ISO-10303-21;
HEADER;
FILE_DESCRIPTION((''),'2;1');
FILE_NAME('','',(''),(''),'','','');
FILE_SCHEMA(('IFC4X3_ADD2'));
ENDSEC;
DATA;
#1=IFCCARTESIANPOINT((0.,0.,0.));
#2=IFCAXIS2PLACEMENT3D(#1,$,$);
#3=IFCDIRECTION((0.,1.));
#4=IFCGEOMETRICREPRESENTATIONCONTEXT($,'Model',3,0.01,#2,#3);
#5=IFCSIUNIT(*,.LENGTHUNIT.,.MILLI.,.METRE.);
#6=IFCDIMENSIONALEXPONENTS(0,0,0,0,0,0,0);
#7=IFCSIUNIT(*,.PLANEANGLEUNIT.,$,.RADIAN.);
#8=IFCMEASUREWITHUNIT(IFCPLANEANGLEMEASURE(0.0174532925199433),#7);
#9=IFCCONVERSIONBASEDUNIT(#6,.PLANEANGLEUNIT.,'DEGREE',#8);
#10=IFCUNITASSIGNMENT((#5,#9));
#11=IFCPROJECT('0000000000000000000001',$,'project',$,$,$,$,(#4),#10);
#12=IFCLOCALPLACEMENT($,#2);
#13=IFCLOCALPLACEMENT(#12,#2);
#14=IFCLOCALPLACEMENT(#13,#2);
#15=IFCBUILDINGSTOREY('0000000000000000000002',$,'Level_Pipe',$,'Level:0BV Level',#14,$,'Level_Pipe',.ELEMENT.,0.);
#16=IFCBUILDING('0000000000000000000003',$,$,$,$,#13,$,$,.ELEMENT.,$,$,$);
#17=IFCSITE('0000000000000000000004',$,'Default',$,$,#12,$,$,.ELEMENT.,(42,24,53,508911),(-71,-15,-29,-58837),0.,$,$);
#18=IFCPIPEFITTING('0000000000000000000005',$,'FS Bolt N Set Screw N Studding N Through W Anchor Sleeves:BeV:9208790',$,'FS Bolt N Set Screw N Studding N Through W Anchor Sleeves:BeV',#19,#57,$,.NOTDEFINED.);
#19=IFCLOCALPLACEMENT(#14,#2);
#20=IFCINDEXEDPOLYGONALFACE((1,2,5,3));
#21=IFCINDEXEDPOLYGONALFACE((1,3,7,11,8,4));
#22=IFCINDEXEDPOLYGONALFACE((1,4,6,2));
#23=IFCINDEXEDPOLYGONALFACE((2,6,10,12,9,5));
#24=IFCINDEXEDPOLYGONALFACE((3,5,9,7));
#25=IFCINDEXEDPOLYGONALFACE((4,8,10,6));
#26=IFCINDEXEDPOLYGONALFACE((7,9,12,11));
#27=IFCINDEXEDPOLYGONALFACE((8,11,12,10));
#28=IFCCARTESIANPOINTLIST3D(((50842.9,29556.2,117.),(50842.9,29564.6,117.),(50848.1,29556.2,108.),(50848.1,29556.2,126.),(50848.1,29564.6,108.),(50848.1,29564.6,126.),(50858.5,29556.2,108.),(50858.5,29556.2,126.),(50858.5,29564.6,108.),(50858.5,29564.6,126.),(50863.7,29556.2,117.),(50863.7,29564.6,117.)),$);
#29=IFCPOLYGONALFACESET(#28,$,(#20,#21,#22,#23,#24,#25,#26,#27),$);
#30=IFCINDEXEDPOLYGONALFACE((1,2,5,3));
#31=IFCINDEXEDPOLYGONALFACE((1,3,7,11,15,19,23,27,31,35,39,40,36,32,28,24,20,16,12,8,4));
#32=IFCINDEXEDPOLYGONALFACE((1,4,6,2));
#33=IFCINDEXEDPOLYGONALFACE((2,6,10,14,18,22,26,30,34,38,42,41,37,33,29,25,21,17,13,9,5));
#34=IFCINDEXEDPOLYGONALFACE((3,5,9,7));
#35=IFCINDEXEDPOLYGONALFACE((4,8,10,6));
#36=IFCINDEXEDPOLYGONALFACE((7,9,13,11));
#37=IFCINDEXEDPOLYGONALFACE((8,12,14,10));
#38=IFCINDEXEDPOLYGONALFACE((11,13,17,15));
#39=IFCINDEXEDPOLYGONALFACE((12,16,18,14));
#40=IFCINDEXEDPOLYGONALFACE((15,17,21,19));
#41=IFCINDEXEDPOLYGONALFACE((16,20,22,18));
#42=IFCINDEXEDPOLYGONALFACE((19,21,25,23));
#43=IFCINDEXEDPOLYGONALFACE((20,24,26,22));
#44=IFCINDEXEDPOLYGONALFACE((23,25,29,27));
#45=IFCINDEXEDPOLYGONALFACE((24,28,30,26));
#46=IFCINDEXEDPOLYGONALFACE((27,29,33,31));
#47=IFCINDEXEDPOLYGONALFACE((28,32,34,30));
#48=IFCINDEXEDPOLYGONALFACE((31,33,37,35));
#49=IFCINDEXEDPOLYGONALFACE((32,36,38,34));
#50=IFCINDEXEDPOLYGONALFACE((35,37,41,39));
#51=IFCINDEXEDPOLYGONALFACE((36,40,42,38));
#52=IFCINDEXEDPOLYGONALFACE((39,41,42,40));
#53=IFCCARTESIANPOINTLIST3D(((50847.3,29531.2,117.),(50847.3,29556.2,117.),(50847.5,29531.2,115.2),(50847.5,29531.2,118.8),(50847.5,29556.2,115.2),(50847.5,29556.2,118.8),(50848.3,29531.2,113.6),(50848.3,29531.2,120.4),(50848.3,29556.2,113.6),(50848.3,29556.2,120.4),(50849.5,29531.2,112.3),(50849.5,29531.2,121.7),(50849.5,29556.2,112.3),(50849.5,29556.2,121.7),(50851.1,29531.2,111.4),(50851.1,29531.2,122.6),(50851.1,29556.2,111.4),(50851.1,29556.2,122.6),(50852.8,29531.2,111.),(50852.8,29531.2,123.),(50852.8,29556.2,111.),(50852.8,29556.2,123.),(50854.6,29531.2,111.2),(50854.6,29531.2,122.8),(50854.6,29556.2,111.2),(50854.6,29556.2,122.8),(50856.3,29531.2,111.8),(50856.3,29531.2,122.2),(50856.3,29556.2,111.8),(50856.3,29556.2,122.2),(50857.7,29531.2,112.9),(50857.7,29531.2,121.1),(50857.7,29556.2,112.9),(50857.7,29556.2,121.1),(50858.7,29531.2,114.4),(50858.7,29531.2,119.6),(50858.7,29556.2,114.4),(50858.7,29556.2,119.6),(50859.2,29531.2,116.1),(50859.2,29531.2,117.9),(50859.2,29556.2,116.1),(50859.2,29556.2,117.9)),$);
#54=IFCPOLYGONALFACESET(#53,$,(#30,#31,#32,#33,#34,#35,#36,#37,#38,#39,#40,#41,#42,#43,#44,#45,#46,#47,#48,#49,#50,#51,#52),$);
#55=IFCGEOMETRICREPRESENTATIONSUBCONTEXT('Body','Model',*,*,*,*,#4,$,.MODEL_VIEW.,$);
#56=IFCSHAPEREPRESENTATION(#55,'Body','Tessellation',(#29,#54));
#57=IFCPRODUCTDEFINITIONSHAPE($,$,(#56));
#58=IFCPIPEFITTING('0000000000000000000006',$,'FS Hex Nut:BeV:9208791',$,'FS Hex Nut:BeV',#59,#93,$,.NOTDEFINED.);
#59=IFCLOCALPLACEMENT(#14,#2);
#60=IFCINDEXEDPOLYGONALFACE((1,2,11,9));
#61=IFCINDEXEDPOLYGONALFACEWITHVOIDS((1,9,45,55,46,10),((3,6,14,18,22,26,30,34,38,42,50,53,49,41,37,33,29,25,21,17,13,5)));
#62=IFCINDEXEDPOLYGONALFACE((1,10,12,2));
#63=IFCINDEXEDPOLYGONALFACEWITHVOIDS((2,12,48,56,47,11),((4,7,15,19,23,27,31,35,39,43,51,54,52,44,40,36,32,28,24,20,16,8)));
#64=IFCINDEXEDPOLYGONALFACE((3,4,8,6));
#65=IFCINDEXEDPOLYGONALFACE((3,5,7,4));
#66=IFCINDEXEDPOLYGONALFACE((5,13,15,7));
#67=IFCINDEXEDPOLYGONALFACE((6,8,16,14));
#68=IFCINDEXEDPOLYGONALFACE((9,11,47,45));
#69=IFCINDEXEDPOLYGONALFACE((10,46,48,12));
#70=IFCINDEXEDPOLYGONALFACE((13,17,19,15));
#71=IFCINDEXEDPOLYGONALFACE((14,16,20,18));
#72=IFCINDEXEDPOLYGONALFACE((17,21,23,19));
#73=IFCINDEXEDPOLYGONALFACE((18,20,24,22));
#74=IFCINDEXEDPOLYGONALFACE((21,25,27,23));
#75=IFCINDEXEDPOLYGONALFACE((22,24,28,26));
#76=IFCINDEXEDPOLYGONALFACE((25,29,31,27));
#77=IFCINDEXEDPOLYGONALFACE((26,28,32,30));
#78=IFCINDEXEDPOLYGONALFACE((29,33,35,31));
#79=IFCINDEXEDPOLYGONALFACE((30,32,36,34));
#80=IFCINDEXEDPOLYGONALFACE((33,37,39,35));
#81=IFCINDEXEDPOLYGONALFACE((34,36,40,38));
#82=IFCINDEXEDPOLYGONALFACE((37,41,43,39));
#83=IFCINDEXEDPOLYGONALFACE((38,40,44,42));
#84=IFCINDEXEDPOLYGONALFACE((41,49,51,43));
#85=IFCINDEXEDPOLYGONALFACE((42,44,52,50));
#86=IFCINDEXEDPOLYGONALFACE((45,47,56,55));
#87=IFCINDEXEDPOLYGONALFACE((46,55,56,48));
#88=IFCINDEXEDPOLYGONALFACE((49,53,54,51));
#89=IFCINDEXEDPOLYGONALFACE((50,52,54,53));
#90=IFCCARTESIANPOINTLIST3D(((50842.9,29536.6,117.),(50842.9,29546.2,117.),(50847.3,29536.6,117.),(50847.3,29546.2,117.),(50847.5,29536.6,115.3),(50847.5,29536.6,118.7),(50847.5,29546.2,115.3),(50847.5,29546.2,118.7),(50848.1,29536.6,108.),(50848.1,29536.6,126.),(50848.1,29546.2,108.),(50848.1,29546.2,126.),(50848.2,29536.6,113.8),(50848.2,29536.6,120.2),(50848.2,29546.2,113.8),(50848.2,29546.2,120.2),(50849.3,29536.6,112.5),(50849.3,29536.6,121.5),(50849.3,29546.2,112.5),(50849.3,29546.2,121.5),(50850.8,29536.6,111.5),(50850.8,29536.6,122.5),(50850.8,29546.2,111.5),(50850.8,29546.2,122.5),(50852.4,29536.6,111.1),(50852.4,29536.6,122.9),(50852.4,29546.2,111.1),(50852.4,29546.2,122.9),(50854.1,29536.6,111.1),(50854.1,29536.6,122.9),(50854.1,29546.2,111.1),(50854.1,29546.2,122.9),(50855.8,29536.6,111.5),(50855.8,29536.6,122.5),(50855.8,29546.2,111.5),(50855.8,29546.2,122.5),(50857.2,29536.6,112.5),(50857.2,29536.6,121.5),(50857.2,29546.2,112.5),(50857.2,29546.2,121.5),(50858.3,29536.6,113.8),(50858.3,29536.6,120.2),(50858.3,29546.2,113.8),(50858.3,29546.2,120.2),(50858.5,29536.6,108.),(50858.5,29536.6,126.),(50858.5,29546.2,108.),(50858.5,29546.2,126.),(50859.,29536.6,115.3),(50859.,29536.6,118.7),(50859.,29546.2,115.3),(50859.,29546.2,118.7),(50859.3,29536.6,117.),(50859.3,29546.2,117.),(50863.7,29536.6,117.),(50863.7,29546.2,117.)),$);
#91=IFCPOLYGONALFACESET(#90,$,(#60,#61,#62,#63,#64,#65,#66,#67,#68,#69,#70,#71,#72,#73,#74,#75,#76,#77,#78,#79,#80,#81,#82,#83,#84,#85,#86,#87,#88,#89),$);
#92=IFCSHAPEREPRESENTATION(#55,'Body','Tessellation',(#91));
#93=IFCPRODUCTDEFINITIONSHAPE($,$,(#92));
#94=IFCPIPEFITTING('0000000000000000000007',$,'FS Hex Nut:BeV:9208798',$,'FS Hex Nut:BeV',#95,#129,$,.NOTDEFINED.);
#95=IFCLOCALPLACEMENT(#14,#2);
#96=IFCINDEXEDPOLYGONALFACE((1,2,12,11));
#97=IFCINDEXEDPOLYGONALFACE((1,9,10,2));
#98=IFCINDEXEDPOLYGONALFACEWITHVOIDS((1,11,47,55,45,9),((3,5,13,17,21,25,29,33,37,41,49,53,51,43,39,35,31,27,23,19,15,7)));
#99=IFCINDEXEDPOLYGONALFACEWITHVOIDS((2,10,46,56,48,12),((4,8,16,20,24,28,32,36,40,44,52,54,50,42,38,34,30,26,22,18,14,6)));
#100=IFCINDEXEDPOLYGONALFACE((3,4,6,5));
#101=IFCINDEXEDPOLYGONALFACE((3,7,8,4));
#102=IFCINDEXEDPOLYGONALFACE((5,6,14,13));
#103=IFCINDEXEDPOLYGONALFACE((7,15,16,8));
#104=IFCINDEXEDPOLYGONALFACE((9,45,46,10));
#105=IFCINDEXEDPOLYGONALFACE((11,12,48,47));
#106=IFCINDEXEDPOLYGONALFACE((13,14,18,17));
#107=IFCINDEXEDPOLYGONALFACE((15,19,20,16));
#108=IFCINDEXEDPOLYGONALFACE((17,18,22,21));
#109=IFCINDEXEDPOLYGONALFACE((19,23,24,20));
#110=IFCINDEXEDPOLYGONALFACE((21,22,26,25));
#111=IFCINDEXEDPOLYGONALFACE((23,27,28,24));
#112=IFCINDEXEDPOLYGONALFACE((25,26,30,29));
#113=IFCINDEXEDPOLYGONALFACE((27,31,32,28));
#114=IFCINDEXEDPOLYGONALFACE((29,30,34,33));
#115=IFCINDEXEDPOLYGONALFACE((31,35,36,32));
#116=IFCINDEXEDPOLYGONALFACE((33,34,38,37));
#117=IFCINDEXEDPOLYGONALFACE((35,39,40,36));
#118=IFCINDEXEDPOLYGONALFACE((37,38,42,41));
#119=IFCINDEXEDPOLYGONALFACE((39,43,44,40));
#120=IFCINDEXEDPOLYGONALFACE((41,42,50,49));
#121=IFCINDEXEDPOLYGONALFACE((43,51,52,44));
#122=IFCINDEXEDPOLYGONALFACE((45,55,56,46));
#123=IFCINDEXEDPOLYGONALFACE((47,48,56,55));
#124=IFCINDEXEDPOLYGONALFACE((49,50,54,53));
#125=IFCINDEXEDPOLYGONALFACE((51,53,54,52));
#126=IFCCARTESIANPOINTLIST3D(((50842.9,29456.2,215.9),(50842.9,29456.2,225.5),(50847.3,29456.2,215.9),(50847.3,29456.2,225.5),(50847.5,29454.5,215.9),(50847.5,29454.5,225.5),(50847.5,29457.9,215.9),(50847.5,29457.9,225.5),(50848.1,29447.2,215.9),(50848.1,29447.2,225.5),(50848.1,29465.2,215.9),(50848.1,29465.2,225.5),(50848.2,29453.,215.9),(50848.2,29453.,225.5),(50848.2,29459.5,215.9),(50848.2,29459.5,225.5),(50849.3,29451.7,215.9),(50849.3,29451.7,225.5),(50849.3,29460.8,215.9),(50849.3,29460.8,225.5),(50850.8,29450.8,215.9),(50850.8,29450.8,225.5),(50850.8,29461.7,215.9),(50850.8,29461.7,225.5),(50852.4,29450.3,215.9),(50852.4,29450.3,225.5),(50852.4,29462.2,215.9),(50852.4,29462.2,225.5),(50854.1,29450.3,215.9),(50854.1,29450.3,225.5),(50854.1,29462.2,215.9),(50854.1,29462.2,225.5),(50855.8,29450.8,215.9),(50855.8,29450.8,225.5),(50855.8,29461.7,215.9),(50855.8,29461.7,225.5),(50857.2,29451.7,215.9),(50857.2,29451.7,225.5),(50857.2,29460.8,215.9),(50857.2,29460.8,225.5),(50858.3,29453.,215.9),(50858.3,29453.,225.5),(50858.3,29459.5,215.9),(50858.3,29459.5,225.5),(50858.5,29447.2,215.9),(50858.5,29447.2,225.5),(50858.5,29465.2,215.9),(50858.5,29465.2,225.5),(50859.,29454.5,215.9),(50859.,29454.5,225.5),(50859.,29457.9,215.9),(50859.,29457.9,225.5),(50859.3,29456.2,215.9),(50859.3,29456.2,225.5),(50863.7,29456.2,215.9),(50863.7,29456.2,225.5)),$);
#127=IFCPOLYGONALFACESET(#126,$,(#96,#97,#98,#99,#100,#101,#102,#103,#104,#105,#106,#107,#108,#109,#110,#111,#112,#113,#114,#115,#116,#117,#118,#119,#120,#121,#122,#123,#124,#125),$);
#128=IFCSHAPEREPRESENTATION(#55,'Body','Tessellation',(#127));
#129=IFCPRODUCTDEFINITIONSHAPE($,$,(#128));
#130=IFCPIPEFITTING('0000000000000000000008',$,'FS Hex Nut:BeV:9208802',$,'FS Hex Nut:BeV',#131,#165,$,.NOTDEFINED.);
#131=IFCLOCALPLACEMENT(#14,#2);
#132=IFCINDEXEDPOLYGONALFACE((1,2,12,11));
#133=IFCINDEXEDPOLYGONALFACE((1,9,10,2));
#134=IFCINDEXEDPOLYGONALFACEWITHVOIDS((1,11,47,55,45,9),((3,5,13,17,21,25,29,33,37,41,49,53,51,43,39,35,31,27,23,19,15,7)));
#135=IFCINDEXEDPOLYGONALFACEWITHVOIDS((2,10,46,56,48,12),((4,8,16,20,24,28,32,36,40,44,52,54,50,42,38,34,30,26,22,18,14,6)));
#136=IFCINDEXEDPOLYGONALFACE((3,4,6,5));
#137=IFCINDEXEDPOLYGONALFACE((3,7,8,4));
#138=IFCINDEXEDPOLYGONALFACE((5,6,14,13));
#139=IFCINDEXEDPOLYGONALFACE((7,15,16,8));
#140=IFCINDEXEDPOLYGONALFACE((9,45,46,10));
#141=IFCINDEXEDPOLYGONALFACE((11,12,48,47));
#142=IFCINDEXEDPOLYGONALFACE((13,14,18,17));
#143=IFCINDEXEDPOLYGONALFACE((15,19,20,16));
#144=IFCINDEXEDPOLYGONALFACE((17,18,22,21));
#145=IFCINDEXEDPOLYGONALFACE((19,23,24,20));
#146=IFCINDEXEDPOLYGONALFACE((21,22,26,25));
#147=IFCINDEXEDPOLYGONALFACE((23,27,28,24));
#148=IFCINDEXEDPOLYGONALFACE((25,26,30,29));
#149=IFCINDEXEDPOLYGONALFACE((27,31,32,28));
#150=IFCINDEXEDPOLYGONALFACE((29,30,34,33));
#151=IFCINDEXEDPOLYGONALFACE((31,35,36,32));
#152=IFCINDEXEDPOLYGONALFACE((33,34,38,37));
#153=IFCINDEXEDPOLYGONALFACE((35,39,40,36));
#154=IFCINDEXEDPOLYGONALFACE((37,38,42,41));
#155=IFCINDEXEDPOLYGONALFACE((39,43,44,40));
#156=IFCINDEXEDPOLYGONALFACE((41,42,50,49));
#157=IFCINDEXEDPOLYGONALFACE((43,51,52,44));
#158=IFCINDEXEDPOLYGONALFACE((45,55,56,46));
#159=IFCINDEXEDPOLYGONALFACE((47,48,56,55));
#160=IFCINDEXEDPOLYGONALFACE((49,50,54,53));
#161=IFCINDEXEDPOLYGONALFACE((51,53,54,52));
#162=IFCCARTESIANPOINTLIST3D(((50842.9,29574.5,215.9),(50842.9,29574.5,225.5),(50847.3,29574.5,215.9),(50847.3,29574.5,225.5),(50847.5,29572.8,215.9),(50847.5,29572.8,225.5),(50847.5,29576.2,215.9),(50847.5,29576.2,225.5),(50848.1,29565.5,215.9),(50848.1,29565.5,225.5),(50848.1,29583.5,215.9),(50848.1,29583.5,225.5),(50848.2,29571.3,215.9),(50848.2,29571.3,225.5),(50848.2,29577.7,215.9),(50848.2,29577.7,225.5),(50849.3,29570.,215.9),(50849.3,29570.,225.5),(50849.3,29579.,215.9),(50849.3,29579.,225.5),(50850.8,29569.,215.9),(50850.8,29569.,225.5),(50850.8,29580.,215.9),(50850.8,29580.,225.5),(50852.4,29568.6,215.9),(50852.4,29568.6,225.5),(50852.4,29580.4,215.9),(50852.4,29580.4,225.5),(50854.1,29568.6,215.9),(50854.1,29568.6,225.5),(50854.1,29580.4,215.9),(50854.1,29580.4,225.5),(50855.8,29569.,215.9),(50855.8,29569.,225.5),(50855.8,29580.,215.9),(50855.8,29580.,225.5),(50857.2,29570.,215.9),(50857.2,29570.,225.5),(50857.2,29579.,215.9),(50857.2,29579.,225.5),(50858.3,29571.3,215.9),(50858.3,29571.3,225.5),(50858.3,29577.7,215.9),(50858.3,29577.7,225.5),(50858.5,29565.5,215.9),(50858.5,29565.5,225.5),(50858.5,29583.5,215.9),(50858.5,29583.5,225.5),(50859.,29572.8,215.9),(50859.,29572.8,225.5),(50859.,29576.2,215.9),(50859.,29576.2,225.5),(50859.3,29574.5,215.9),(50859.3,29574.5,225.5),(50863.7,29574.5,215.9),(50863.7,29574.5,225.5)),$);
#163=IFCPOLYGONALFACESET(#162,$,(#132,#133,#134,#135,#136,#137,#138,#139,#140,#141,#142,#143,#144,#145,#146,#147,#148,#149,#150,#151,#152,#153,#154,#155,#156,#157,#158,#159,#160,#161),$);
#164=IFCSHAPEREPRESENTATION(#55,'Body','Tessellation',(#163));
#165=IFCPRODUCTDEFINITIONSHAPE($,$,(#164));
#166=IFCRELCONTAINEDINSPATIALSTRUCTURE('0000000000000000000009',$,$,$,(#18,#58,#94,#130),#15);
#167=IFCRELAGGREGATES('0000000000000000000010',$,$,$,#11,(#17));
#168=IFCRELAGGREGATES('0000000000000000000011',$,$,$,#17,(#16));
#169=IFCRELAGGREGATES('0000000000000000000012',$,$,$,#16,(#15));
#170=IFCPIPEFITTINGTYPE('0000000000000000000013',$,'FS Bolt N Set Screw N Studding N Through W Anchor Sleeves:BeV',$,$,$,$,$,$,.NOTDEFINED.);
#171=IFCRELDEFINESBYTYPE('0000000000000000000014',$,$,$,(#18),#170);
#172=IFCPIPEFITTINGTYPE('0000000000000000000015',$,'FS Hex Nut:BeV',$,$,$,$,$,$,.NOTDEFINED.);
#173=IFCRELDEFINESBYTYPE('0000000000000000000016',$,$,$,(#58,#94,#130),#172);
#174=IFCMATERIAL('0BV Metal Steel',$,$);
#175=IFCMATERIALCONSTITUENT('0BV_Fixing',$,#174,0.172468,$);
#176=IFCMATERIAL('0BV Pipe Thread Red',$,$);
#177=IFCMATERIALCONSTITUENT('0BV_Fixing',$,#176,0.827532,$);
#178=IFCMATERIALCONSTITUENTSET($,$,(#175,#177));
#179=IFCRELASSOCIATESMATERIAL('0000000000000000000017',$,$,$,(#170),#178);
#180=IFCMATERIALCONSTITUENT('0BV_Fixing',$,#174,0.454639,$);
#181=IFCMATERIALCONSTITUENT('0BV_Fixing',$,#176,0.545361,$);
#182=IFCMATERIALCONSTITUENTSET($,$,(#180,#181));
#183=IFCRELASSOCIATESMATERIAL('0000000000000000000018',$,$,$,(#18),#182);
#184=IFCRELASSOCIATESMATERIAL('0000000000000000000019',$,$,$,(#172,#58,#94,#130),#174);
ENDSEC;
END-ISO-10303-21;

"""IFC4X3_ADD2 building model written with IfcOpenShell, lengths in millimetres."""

from ifc_helpers import new_model, entity, si_unit, converted_unit, direction, frame, frame_2d, origin, origin_2d_with_axis, place, context, subcontext, project, spatial, polyline, circle_curve, parameter, trimmed, segment, composite_curve, circle, outline, extrude, source, transform, mapped, material, constituent, constituent_set, type_object, type_shapes, element, save


model = new_model("IFC4X3_ADD2")

# Units and contexts
model_context = context("Model", 3, precision=0.01, world=origin(), true_north=direction((0.0, 1.0)))
body_context = subcontext(model_context, "Body", "Model", "MODEL_VIEW")
ifc_project = project(units=[si_unit("LENGTHUNIT", "METRE", prefix="MILLI"), converted_unit("PLANEANGLEUNIT", "DEGREE", entity("IfcPlaneAngleMeasure", 0.0174532925199433), si_unit("PLANEANGLEUNIT", "RADIAN"), dimensions=[0, 0, 0, 0, 0, 0, 0])], contexts=[model_context])

# Site, building, storey
site_placement = place(None, origin())
site = spatial("IfcSite", under=ifc_project, at=site_placement, Name="Default", CompositionType="ELEMENT", RefLatitude=(42, 24, 53, 508911), RefLongitude=(-71, -15, -29, -58837), RefElevation=0.0)
building_placement = place(site_placement, origin())
building = spatial("IfcBuilding", under=site, at=building_placement, CompositionType="ELEMENT")
storey_placement = place(building_placement, origin())
storey = spatial("IfcBuildingStorey", under=building, at=storey_placement, Name="Level_Pipe", ObjectType="Level:0BV Level", LongName="Level_Pipe", CompositionType="ELEMENT", Elevation=0.0)

# Pipe fittings
ifc_material_1 = material(Name="0BV Metal Steel")
ifc_constituent_1 = constituent(ifc_material_1, Name="0BV_Fixing", fraction=0.454639)
ifc_material_2 = material(Name="0BV Pipe Thread Red")
ifc_constituent_2 = constituent(ifc_material_2, Name="0BV_Fixing", fraction=0.545361)
ifc_constituent_set_1 = constituent_set(constituents=[ifc_constituent_1, ifc_constituent_2])
ifc_constituent_3 = constituent(ifc_material_1, Name="0BV_Fixing", fraction=0.172468)
ifc_constituent_4 = constituent(ifc_material_2, Name="0BV_Fixing", fraction=0.827532)
ifc_constituent_set_2 = constituent_set(constituents=[ifc_constituent_3, ifc_constituent_4])
pipe_fitting_type_1 = type_object("IfcPipeFittingType", Name="FS Bolt N Set Screw N Studding N Through W Anchor Sleeves:BeV", PredefinedType="NOTDEFINED", material=ifc_constituent_set_2)
shared_shape_1 = source(origin(), body_context, "Body", "SweptSolid", [
    extrude(outline(polyline([(-5.2, -9.0), (5.2, -9.0), (10.4, 0.0), (5.2, 9.0), (-5.2, 9.0), (-10.4, 0.0), (-5.2, -9.0)])), frame((-8.4, 0.0, 0.0), z_axis=(1.0, 0.0, 0.0), x_axis=(0.0, -1.0, 0.0)), (0.0, 0.0, 1.0), 8.4),
    extrude(circle(Radius=6.0, at=frame_2d((0.0, 0.0), x_axis=(1.0, 0.0))), frame((0.0, 0.0, 0.0), z_axis=(1.0, 0.0, 0.0), x_axis=(0.0, -1.0, 0.0)), (0.0, 0.0, 1.0), 25.0),
])
type_shapes(pipe_fitting_type_1, [shared_shape_1])
pipe_fitting_1_placement = place(storey_placement, frame((50853.3, 29556.2, 117.0), z_axis=(0.0, 0.0, 1.0), x_axis=(0.0, -1.0, 0.0)))
element("IfcPipeFitting", 1, at=pipe_fitting_1_placement, inside=storey, type_object=pipe_fitting_type_1, material=ifc_constituent_set_1, Name="FS Bolt N Set Screw N Studding N Through W Anchor Sleeves:BeV:9208790", ObjectType="FS Bolt N Set Screw N Studding N Through W Anchor Sleeves:BeV", PredefinedType="NOTDEFINED", context=body_context, shape_type="MappedRepresentation", body=[
    mapped(shared_shape_1, transform((0.0, 0.0, 0.0), scale=1.0)),
])
pipe_fitting_type_2 = type_object("IfcPipeFittingType", Name="FS Hex Nut:BeV", PredefinedType="NOTDEFINED", material=ifc_material_1)
shared_shape_2 = source(origin(), body_context, "Body", "SweptSolid", [
    extrude(outline(polyline([(-5.2, -9.0), (5.2, -9.0), (10.4, 0.0), (5.2, 9.0), (-5.2, 9.0), (-10.4, 0.0), (-5.2, -9.0)]), holes=[composite_curve([segment(trimmed(circle_curve(origin_2d_with_axis(), 6.0), [parameter(0.0)], [parameter(180.0)], True, "PARAMETER"), False, "CONTINUOUS"), segment(trimmed(circle_curve(origin_2d_with_axis(), 6.0), [parameter(180.0)], [parameter(0.0)], True, "PARAMETER"), False, "CONTINUOUS")], self_intersect=False)]), frame((0.0, 10.4, 9.0), z_axis=(1.0, 0.0, 0.0), x_axis=(0.0, -1.0, 0.0)), (0.0, 0.0, 1.0), 9.6),
])
type_shapes(pipe_fitting_type_2, [shared_shape_2])
for number, where, z_axis, x_axis, name in (
    (2, (50842.9, 29546.2, 108.0), (0.0, 0.0, 1.0), (0.0, -1.0, 0.0), "FS Hex Nut:BeV:9208791"),
    (3, (50842.9, 29465.2, 225.5), (0.0, -1.0, 0.0), (0.0, 0.0, -1.0), "FS Hex Nut:BeV:9208798"),
    (4, (50842.9, 29583.5, 225.5), (0.0, -1.0, 0.0), (0.0, 0.0, -1.0), "FS Hex Nut:BeV:9208802"),
):
    element("IfcPipeFitting", number, at=place(storey_placement, frame(where, z_axis=z_axis, x_axis=x_axis)), inside=storey, type_object=pipe_fitting_type_2, material=ifc_material_1, Name=name, ObjectType="FS Hex Nut:BeV", PredefinedType="NOTDEFINED", context=body_context, shape_type="MappedRepresentation", body=[
        mapped(shared_shape_2, transform((0.0, 0.0, 0.0), scale=1.0)),
    ])

save(model, "model.ifc")
